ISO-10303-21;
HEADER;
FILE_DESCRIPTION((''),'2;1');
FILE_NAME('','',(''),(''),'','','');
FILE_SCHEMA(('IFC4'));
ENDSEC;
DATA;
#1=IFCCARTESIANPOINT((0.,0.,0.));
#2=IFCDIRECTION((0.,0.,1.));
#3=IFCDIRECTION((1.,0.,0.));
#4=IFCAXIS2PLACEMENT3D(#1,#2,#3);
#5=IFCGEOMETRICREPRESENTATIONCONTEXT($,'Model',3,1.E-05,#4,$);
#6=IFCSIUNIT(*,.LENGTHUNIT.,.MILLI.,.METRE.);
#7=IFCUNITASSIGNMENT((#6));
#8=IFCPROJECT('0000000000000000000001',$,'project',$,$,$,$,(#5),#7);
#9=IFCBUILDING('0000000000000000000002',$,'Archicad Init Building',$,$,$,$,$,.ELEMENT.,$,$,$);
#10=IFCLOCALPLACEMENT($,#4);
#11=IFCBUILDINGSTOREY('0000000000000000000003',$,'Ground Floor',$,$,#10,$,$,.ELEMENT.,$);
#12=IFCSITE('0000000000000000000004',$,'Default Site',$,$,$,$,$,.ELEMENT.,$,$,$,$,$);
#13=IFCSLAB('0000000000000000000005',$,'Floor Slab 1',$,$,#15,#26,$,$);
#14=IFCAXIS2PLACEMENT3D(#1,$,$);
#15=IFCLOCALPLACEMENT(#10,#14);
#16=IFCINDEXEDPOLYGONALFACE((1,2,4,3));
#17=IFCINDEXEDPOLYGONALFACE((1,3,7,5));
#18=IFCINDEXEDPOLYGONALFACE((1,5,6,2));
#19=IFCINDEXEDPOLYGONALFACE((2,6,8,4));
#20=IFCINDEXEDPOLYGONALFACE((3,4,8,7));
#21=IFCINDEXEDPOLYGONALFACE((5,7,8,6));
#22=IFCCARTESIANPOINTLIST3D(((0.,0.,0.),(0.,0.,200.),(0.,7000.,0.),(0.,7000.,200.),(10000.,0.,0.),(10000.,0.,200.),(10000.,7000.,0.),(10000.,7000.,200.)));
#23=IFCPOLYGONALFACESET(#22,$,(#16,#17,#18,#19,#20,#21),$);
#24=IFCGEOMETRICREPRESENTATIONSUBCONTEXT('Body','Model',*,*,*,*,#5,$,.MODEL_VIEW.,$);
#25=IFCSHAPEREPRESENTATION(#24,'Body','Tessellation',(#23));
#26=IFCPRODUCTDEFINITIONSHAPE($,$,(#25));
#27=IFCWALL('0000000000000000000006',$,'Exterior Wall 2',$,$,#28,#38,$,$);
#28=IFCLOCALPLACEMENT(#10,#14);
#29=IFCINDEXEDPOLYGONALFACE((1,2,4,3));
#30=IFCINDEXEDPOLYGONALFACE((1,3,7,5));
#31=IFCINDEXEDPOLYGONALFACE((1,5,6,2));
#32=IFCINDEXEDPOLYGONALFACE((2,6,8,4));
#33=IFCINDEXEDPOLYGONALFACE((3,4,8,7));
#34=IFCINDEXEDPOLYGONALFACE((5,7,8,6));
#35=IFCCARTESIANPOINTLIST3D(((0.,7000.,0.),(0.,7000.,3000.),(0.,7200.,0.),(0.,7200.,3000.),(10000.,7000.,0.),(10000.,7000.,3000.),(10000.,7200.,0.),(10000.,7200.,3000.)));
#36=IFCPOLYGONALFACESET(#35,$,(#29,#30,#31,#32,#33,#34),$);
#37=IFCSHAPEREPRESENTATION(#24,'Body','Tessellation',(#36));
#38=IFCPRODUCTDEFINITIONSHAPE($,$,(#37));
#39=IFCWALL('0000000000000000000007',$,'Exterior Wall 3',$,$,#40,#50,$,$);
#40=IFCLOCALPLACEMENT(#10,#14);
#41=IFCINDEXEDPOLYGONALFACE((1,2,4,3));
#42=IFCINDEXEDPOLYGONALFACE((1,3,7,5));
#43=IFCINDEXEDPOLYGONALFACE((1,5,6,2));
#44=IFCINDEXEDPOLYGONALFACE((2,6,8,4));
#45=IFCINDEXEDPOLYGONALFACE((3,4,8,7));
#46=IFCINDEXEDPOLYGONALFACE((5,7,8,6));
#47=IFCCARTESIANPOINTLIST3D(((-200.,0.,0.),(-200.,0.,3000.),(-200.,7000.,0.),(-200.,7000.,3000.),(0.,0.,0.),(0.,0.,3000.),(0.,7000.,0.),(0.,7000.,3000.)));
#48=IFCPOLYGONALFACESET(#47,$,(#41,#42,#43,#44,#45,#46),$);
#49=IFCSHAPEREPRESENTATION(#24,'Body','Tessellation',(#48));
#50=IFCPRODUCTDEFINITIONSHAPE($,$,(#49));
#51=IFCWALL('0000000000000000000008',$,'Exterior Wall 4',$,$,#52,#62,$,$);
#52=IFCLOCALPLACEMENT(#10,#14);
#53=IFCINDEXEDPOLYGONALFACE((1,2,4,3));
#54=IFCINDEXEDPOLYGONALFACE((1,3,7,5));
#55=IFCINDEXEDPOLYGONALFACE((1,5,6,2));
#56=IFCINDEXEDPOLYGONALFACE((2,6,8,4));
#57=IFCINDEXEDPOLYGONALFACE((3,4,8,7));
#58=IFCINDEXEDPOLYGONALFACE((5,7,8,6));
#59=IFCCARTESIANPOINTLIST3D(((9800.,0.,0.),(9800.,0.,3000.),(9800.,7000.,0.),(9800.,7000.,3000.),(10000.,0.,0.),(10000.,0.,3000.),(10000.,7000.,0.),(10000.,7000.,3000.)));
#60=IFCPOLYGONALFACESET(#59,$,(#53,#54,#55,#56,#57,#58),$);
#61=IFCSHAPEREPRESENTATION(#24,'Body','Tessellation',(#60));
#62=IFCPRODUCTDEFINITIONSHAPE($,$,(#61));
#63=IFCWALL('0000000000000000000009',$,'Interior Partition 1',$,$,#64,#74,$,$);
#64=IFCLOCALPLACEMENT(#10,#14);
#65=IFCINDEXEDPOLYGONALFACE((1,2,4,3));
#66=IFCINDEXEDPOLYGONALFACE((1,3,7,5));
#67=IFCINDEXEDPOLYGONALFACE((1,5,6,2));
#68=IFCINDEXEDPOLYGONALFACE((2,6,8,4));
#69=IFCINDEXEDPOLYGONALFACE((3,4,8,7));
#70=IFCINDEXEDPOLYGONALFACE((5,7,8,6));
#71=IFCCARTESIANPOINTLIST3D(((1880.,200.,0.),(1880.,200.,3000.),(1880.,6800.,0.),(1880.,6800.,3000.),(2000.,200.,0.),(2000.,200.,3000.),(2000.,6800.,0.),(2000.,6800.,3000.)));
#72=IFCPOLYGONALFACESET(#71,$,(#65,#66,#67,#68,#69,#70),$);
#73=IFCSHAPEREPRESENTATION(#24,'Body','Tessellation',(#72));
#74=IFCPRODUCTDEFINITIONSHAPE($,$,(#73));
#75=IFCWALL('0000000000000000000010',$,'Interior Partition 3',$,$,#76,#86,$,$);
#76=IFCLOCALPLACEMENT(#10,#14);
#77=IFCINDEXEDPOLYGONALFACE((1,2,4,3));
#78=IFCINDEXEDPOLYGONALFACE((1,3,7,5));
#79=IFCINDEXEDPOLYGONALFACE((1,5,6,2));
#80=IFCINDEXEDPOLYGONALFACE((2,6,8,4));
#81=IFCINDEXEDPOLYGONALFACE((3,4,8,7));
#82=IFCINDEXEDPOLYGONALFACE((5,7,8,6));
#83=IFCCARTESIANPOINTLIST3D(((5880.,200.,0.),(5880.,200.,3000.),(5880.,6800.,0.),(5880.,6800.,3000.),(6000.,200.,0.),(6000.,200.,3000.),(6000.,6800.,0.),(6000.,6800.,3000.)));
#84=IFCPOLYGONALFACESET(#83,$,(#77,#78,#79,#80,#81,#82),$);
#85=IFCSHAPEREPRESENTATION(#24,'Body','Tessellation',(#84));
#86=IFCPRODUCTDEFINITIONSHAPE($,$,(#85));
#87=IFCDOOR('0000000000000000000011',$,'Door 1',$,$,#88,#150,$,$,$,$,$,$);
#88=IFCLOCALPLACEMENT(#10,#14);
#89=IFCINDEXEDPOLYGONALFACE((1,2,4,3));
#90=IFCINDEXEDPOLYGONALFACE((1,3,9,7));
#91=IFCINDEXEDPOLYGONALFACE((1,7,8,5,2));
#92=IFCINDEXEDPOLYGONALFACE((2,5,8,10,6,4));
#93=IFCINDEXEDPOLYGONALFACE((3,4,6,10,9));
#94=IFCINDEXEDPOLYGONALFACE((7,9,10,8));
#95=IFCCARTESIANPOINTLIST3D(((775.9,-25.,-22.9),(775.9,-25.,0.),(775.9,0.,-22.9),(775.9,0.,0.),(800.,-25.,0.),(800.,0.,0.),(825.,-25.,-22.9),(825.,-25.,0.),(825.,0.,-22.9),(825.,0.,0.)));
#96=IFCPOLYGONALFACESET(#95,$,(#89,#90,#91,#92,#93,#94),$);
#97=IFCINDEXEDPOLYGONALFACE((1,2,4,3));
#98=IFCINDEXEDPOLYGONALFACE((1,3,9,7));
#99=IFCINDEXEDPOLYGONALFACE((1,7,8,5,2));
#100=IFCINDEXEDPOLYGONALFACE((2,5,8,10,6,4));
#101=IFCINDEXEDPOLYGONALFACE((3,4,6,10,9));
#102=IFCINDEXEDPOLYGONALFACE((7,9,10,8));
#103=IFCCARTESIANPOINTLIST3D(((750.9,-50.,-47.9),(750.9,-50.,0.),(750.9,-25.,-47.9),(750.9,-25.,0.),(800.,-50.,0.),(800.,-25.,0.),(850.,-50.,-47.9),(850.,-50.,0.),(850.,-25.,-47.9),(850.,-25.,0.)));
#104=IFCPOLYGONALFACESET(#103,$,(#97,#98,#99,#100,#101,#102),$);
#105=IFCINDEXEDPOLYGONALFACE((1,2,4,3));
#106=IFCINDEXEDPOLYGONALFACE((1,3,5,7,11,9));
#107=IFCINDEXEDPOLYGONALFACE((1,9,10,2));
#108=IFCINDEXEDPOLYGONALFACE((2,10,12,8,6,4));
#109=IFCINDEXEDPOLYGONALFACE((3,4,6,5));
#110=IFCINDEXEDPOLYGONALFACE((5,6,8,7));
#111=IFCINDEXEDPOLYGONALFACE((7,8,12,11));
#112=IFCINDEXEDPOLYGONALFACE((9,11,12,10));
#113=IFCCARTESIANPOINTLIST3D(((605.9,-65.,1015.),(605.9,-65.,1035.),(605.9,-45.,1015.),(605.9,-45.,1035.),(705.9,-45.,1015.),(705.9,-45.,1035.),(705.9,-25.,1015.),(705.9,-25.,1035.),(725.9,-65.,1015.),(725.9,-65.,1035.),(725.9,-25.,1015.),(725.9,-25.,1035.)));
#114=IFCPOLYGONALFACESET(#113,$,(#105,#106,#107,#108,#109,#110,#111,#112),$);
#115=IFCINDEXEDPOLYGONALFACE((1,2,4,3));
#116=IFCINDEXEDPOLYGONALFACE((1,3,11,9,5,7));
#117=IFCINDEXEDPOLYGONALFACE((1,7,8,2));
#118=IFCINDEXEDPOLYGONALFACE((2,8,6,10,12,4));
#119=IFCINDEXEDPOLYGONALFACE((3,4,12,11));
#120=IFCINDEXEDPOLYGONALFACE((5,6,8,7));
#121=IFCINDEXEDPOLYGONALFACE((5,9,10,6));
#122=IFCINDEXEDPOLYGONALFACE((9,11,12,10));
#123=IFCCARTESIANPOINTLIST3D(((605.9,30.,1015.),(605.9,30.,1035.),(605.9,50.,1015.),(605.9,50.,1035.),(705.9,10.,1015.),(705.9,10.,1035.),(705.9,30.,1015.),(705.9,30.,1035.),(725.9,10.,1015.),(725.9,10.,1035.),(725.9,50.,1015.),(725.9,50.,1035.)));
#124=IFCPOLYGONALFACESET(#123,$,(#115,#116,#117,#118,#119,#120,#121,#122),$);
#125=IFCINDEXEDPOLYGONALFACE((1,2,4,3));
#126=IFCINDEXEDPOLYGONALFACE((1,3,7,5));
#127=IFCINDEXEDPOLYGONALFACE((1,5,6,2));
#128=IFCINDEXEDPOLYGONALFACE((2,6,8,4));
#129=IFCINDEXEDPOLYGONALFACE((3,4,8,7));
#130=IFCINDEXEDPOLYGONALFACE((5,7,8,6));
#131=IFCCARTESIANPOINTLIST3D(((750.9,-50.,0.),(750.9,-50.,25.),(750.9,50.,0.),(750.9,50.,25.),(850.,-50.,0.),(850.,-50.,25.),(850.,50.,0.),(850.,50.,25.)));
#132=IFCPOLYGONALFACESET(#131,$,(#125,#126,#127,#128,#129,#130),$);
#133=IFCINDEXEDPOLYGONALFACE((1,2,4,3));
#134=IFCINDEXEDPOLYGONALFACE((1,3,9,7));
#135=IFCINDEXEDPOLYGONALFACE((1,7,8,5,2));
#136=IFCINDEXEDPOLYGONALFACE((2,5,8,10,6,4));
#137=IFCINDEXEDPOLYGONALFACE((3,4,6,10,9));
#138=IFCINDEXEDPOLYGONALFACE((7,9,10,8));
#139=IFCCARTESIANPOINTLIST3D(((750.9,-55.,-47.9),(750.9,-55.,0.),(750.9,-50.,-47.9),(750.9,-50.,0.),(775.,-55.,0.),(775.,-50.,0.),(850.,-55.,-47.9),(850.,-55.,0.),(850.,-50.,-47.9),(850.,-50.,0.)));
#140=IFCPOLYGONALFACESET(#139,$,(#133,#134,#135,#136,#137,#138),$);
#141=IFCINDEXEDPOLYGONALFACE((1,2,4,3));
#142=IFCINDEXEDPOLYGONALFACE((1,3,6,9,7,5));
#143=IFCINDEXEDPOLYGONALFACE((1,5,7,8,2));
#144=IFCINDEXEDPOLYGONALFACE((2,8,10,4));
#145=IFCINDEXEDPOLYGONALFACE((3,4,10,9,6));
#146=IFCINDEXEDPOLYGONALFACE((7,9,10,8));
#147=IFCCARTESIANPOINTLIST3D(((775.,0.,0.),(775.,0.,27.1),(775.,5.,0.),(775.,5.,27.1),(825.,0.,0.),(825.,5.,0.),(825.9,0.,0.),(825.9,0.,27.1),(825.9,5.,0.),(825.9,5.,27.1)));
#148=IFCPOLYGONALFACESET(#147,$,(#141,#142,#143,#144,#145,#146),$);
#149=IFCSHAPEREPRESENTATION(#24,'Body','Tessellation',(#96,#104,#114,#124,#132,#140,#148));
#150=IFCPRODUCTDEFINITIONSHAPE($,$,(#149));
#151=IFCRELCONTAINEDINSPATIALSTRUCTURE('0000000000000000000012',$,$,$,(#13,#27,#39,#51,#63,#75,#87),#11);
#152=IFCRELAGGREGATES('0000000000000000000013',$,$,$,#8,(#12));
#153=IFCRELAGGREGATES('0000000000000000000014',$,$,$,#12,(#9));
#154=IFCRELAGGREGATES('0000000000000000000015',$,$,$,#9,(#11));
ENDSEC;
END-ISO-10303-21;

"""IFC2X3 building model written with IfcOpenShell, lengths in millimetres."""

from ifc_helpers import new_model, si_unit, frame, origin_with_axes, place, context, subcontext, project, spatial, polyline, outline, extrude, element, save


model = new_model("IFC2X3")

# Units and contexts
model_context = context("Model", 3, precision=1e-05, world=origin_with_axes())
body_context = subcontext(model_context, "Body", "Model", "MODEL_VIEW")
ifc_project = project(units=[si_unit("LENGTHUNIT", "METRE", prefix="MILLI")], contexts=[model_context])

# Site, building, storey
site = spatial("IfcSite", under=ifc_project, Name="Default Site", CompositionType="ELEMENT")
building = spatial("IfcBuilding", under=site, Name="Archicad Init Building", CompositionType="ELEMENT")
storey_placement = place(None, origin_with_axes())
storey = spatial("IfcBuildingStorey", under=building, at=storey_placement, Name="Ground Floor", CompositionType="ELEMENT")

# Slab
slab_placement = place(storey_placement, origin_with_axes())
element("IfcSlab", 1, at=slab_placement, inside=storey, Name="Floor Slab 1", context=body_context, shape_type="SweptSolid", body=[
    extrude(outline(polyline([(0.0, 0.0), (10000.0, 0.0), (10000.0, 7000.0), (0.0, 7000.0), (0.0, 0.0)])), origin_with_axes(), (0.0, 0.0, 1.0), 200.0),
])

# Walls
wall_placement = place(storey_placement, frame((0.0, 7000.0, 0.0), z_axis=(0.0, 0.0, 1.0), x_axis=(1.0, 0.0, 0.0)))
element("IfcWall", 2, at=wall_placement, inside=storey, Name="Exterior Wall 2", context=body_context, shape_type="SweptSolid", body=[
    extrude(outline(polyline([(0.0, 0.0), (0.0, 200.0), (10000.0, 200.0), (10000.0, 0.0), (0.0, 0.0)])), origin_with_axes(), (0.0, 0.0, 1.0), 3000.0),
])
for number, where, z_axis, x_axis, name in (
    (3, (0.0, 0.0, 0.0), (0.0, 0.0, 1.0), (0.0, 1.0, 0.0), "Exterior Wall 3"),
    (4, (10000.0, 0.0, 0.0), (0.0, 0.0, 1.0), (0.0, 1.0, 0.0), "Exterior Wall 4"),
):
    element("IfcWall", number, at=place(storey_placement, frame(where, z_axis=z_axis, x_axis=x_axis)), inside=storey, Name=name, context=body_context, shape_type="SweptSolid", body=[
        extrude(outline(polyline([(0.0, 0.0), (0.0, 200.0), (7000.0, 200.0), (7000.0, 0.0), (0.0, 0.0)])), origin_with_axes(), (0.0, 0.0, 1.0), 3000.0),
    ])
for number, where, z_axis, x_axis, name in (
    (5, (2000.0, 200.0, 0.0), (0.0, 0.0, 1.0), (0.0, 1.0, 0.0), "Interior Partition 1"),
    (6, (6000.0, 200.0, 0.0), (0.0, 0.0, 1.0), (0.0, 1.0, 0.0), "Interior Partition 3"),
):
    element("IfcWall", number, at=place(storey_placement, frame(where, z_axis=z_axis, x_axis=x_axis)), inside=storey, Name=name, context=body_context, shape_type="SweptSolid", body=[
        extrude(outline(polyline([(0.0, 0.0), (0.0, 120.0), (6600.0, 120.0), (6600.0, 0.0), (0.0, 0.0)])), origin_with_axes(), (0.0, 0.0, 1.0), 3000.0),
    ])

# Door
door_1_placement = place(storey_placement, frame((800.0, -50.0, 0.0), z_axis=(0.0, 0.0, 1.0), x_axis=(1.0, 0.0, 0.0)))
element("IfcDoor", 7, at=door_1_placement, inside=storey, Name="Door 1", context=body_context, shape_type="SweptSolid", body=[
    extrude(outline(polyline([(0.0, 0.0), (0.0, 2.1), (0.9, 2.1), (0.9, 0.0), (-24.1, 0.0), (-24.1, -22.9), (25.0, -22.9), (25.0, 0.0), (0.0, 0.0)])), frame((0.0, 25.0, 0.0), z_axis=(0.0, -1.0, 0.0), x_axis=(1.0, 0.0, 0.0)), (0.0, 0.0, -1.0), 25.0),
    extrude(outline(polyline([(0.0, 0.0), (0.0, 2.1), (0.9, 2.1), (0.9, 0.0), (-49.1, 0.0), (-49.1, -47.9), (50.0, -47.9), (50.0, 0.0), (0.0, 0.0)])), frame((0.0, 0.0, 0.0), z_axis=(0.0, -1.0, 0.0), x_axis=(1.0, 0.0, 0.0)), (0.0, 0.0, -1.0), 25.0),
    extrude(outline(polyline([(0.0, 0.0), (-49.1, 0.0), (-49.1, 35.0), (0.0, 35.0), (0.0, 0.0)])), frame((25.0, 25.0, 25.0), z_axis=(0.0, 0.0, 1.0), x_axis=(1.0, 0.0, 0.0)), (0.0, 0.0, 1.0), -47.9),
    extrude(outline(polyline([(0.0, 0.0), (0.0, -40.0), (-120.0, -40.0), (-120.0, -20.0), (-20.0, -20.0), (-20.0, 0.0), (0.0, 0.0)])), frame((-74.1, 25.0, 1015.0), z_axis=(0.0, 0.0, 1.0), x_axis=(1.0, 0.0, 0.0)), (0.0, 0.0, 1.0), 20.0),
    extrude(outline(polyline([(0.0, 0.0), (0.0, 40.0), (-120.0, 40.0), (-120.0, 20.0), (-20.0, 20.0), (-20.0, 0.0), (0.0, 0.0)])), frame((-74.1, 60.0, 1015.0), z_axis=(0.0, 0.0, 1.0), x_axis=(1.0, 0.0, 0.0)), (0.0, 0.0, 1.0), 20.0),
    extrude(outline(polyline([(0.0, 0.0), (-99.1, 0.0), (-99.1, 100.0), (0.0, 100.0), (0.0, 0.0)])), frame((50.0, 0.0, 0.0), z_axis=(0.0, 0.0, 1.0), x_axis=(1.0, 0.0, 0.0)), (0.0, 0.0, 1.0), 25.0),
    extrude(outline(polyline([(0.0, 0.0), (0.0, 27.1), (50.9, 27.1), (50.9, 0.0), (-24.1, 0.0), (-24.1, -47.9), (75.0, -47.9), (75.0, 0.0), (0.0, 0.0)])), frame((-25.0, -5.0, 0.0), z_axis=(0.0, -1.0, 0.0), x_axis=(1.0, 0.0, 0.0)), (0.0, 0.0, -1.0), 5.0),
    extrude(outline(polyline([(0.0, 0.0), (0.0, 27.1), (50.9, 27.1), (50.9, 0.0), (0.9, 0.0), (0.9, -22.9), (50.0, -22.9), (50.0, 0.0), (0.0, 0.0)])), frame((-25.0, 50.0, 0.0), z_axis=(0.0, -1.0, 0.0), x_axis=(1.0, 0.0, 0.0)), (0.0, 0.0, -1.0), 5.0),
])

save(model, "model.ifc")
